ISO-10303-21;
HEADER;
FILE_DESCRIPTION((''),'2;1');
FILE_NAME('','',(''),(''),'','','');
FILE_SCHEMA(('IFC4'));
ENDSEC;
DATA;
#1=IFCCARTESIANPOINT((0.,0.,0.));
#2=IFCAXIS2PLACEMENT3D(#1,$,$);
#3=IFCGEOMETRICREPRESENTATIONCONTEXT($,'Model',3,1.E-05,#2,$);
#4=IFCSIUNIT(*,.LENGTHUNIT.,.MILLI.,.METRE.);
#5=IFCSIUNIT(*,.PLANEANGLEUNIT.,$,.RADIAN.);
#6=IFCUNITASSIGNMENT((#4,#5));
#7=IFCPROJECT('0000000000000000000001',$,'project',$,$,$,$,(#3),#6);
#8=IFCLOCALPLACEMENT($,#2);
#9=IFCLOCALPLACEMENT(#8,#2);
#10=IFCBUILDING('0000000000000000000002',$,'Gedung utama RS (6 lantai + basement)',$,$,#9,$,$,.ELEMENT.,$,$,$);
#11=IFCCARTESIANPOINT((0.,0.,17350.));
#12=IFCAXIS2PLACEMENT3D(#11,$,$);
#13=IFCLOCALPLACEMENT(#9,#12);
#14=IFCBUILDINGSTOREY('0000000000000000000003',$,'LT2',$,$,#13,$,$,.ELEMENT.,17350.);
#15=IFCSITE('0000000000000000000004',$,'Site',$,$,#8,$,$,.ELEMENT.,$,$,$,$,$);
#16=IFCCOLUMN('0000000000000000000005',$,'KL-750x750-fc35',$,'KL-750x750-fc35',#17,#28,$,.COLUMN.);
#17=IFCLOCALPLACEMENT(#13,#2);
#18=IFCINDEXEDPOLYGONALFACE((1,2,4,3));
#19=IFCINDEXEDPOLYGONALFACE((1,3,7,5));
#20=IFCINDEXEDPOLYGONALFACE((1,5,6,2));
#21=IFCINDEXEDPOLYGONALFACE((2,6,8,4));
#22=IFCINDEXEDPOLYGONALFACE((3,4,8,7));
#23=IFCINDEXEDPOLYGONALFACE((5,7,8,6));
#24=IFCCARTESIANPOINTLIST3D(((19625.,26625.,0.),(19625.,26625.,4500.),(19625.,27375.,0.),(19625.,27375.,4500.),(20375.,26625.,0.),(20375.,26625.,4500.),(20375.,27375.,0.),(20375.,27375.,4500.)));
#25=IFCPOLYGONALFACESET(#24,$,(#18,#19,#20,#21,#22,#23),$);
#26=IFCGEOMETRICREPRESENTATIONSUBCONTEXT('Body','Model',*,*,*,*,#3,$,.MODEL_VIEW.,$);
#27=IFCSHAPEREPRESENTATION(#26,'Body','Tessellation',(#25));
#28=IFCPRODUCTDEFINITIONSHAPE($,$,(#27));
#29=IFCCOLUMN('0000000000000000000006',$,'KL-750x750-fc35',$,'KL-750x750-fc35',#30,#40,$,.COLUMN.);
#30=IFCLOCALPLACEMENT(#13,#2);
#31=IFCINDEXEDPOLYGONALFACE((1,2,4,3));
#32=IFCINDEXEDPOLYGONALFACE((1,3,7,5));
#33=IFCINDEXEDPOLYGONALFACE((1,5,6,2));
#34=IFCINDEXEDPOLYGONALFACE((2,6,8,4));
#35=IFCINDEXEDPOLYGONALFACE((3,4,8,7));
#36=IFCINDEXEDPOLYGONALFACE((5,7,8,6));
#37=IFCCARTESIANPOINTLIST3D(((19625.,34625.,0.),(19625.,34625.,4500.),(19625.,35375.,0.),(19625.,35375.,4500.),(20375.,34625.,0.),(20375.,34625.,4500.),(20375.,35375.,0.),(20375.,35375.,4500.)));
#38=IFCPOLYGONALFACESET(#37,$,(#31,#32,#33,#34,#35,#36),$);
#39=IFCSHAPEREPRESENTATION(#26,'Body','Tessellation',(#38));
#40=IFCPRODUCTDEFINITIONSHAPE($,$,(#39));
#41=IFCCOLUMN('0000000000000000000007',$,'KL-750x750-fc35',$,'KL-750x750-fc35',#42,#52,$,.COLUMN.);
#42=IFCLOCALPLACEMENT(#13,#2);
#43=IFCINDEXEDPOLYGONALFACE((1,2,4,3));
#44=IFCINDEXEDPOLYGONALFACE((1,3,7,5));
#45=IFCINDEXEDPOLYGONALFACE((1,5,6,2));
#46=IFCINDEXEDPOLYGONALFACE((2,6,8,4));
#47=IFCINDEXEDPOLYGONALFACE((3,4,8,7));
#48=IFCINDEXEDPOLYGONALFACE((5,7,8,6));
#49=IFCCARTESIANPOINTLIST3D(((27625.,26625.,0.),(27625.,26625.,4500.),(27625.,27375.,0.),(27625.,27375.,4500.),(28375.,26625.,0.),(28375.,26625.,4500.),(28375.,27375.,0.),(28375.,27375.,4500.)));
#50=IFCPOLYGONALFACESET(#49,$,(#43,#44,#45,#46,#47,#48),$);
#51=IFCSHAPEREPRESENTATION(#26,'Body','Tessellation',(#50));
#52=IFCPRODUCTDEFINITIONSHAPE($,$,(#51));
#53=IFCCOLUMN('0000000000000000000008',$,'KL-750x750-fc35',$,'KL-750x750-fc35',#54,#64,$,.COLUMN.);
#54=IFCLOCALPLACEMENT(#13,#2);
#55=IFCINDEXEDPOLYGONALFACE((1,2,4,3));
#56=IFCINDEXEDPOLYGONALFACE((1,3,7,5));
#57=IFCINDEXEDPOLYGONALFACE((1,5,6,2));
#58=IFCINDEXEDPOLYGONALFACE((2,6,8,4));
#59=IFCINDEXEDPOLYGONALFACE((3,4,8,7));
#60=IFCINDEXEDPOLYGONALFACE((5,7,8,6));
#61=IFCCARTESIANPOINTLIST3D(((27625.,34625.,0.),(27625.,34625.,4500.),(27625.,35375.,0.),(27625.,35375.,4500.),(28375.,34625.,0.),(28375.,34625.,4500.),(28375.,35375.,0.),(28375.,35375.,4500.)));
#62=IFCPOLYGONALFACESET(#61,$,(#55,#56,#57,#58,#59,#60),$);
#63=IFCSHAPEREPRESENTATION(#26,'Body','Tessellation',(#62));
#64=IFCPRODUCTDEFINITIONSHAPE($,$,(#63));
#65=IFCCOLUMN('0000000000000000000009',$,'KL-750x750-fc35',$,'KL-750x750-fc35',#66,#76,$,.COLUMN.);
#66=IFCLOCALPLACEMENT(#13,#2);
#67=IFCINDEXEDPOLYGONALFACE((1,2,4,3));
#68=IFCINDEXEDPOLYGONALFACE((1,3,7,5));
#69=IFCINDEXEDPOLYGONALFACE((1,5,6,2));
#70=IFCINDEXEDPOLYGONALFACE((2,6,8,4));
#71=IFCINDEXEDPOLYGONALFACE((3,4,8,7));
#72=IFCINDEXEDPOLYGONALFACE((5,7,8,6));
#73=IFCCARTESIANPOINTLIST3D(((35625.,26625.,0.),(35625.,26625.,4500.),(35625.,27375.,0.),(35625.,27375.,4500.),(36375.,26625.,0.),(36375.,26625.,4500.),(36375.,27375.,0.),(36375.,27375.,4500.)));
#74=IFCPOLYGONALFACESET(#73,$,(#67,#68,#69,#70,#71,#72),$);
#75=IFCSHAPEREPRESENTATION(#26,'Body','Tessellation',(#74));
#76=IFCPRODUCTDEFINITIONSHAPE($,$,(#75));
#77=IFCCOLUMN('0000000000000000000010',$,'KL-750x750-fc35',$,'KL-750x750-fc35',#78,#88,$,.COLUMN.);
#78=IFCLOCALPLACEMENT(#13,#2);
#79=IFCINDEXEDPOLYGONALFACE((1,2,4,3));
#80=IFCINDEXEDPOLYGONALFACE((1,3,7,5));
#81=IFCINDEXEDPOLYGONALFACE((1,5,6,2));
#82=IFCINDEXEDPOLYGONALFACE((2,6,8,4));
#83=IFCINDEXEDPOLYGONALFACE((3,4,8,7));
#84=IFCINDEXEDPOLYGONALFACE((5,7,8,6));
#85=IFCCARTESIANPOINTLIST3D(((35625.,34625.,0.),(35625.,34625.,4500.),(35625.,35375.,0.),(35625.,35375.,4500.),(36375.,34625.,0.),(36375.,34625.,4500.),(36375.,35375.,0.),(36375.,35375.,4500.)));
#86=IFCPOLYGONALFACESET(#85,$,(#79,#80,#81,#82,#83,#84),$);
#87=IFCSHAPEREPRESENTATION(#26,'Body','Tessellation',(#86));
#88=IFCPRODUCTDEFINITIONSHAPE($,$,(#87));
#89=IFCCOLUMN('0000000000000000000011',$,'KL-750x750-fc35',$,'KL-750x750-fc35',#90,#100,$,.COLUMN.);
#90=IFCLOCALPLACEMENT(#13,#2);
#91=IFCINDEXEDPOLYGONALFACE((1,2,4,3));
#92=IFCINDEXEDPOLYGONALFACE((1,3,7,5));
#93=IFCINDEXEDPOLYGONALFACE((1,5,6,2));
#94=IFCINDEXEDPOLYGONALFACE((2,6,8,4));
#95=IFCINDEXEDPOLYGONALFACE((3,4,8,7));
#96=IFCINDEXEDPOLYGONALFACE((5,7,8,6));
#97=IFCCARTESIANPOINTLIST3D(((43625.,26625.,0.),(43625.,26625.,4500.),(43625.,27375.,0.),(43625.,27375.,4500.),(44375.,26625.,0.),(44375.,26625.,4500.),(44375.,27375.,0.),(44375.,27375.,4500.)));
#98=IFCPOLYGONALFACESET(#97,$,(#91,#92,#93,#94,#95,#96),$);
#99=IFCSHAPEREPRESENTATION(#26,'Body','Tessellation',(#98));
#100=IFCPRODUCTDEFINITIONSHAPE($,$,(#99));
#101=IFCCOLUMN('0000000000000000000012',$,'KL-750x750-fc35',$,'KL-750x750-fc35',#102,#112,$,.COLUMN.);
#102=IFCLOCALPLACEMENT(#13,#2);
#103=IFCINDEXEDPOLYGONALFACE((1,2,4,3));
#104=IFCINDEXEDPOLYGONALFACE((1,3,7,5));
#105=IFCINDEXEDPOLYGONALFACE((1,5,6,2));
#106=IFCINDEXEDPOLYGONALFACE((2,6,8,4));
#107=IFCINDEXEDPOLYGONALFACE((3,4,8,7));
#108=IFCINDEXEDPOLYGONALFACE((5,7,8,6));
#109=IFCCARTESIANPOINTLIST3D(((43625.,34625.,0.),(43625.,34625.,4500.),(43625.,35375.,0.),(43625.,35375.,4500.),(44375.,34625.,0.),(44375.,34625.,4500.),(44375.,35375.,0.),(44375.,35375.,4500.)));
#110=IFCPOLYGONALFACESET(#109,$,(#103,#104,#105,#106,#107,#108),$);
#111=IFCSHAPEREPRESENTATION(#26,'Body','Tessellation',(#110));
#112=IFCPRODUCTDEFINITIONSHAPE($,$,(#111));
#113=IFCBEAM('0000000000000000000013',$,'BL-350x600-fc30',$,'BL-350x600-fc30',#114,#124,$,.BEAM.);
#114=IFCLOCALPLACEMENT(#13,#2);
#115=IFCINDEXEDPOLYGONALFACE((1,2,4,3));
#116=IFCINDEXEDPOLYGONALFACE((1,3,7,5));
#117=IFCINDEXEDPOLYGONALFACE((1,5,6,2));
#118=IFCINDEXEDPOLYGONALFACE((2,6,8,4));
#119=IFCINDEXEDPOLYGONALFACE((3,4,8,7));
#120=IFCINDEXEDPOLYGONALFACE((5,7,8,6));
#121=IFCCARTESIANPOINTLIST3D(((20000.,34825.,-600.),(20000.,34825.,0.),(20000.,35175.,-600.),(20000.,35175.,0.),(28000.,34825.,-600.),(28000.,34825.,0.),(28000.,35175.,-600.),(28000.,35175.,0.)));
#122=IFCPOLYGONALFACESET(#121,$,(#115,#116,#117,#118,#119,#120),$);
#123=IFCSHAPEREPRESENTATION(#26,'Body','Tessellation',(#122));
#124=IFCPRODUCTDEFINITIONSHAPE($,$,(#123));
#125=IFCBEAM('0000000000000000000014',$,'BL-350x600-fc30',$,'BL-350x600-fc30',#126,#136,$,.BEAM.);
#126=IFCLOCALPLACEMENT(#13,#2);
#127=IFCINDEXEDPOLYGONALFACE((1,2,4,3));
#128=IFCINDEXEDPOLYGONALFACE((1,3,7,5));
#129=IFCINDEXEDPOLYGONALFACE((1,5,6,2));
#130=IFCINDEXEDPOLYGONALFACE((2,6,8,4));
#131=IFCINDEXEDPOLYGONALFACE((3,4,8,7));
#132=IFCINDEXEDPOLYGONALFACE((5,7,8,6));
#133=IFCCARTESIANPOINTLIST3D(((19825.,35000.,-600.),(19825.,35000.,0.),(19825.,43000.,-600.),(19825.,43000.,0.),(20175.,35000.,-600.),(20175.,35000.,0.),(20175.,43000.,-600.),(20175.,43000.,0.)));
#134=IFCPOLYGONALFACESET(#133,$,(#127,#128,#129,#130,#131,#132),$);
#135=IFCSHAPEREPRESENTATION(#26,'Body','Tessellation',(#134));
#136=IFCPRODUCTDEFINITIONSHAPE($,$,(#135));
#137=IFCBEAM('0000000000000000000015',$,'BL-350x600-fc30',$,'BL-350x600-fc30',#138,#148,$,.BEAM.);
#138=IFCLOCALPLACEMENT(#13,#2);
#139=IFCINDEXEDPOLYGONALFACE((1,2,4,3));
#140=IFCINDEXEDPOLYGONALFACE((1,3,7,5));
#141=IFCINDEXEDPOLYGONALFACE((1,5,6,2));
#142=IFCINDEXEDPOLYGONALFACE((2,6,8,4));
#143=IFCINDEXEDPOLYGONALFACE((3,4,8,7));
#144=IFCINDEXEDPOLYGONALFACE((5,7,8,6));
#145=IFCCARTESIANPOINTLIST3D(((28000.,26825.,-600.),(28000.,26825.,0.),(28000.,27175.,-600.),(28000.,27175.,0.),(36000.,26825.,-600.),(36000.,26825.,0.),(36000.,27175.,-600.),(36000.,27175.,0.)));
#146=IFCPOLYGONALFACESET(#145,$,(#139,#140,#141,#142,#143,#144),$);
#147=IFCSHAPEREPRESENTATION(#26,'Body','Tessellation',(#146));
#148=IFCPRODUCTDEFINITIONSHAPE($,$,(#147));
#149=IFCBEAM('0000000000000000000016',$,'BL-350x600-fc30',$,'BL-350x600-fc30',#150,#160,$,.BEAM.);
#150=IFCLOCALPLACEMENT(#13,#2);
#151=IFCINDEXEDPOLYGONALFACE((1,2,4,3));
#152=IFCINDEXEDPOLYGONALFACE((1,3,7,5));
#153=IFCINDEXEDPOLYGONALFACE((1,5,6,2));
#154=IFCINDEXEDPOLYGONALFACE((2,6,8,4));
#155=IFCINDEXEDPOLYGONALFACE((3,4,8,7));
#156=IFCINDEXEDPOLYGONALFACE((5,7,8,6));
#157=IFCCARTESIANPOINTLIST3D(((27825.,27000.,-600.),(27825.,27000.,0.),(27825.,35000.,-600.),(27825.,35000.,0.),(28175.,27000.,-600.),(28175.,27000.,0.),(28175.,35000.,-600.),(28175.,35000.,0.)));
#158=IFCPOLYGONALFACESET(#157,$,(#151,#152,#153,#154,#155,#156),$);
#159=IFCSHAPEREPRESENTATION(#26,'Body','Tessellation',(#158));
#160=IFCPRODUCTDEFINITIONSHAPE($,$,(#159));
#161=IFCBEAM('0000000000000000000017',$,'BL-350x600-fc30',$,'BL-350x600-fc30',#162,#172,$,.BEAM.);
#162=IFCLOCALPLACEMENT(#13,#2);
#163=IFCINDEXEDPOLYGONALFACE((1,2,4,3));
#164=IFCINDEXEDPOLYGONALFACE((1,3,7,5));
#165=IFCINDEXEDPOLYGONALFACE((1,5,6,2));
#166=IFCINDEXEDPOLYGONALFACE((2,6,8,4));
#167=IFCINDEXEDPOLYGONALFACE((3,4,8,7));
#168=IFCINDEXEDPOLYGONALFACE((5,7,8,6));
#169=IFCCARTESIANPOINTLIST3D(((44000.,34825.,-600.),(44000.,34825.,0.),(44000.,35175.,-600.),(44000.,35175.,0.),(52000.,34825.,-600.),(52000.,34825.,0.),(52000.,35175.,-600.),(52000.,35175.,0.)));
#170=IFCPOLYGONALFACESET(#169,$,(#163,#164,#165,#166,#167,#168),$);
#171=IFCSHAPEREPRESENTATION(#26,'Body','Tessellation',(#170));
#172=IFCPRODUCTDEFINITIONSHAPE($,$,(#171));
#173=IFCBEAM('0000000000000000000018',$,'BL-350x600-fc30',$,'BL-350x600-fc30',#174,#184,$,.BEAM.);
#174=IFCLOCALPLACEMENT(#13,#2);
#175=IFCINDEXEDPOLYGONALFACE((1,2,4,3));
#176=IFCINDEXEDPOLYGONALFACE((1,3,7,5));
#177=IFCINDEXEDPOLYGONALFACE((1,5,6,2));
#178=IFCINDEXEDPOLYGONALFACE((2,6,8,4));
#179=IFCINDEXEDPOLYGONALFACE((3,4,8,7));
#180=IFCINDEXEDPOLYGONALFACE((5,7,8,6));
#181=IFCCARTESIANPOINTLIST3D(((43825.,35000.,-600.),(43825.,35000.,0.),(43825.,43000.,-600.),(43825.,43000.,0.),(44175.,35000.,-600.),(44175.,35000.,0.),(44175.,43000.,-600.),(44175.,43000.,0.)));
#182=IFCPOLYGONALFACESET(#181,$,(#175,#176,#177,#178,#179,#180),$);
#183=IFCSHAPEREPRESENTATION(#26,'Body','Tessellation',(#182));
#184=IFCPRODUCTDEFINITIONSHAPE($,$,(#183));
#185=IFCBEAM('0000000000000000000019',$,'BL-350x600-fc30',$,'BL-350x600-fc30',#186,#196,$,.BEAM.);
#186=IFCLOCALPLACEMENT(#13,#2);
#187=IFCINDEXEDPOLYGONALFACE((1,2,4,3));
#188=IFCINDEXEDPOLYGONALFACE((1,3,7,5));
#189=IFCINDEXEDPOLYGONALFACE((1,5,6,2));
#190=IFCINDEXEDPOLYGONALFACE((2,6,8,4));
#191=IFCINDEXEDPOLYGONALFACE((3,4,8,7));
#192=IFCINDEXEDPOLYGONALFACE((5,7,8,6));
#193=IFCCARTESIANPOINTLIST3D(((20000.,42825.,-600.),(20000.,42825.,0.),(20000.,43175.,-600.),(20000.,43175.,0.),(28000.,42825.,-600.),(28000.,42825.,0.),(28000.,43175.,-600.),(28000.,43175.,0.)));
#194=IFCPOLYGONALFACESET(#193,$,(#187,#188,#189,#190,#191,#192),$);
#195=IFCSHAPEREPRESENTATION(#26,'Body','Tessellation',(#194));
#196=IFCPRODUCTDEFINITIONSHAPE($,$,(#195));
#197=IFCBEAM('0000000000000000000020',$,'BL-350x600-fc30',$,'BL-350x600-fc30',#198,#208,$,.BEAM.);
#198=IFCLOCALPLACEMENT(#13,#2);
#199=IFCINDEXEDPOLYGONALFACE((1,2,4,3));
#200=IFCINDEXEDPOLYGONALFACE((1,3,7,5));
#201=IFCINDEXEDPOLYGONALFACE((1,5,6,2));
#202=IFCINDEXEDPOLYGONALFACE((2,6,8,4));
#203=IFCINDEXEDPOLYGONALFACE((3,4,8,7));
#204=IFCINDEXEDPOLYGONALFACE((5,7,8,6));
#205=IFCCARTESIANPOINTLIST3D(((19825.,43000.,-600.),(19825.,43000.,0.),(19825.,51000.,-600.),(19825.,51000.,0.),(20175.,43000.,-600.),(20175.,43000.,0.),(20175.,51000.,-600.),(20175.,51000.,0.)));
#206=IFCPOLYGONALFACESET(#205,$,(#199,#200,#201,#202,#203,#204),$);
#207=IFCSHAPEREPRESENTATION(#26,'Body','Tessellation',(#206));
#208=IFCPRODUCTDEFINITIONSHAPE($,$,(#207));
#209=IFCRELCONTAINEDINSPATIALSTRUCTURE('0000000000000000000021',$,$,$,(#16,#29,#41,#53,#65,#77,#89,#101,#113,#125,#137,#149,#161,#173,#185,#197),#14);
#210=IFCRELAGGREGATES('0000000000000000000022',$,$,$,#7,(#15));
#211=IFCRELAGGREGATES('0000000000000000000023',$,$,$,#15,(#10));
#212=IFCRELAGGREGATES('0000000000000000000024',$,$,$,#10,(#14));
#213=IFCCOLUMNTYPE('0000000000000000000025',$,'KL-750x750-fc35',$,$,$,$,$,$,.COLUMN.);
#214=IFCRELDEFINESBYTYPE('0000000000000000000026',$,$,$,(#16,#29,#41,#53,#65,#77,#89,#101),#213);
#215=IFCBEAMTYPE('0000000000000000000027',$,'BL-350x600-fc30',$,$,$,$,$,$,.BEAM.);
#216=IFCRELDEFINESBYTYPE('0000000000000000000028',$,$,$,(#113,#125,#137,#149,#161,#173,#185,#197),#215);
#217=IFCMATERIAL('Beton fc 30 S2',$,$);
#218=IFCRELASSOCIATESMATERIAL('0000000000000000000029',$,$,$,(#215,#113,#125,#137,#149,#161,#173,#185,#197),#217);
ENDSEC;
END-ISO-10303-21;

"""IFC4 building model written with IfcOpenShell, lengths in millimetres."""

from ifc_helpers import new_model, si_unit, frame, origin, origin_2d, place, context, subcontext, project, spatial, rectangle, extrude, material, material_profile, profile_set, profile_usage, type_object, element, save


model = new_model("IFC4")

# Units and contexts
model_context = context("Model", 3, precision=1e-05, world=origin())
body_context = subcontext(model_context, "Body", "Model", "MODEL_VIEW")
ifc_project = project(units=[si_unit("LENGTHUNIT", "METRE", prefix="MILLI"), si_unit("PLANEANGLEUNIT", "RADIAN")], contexts=[model_context])

# Site, building, storey
site_placement = place(None, origin())
site = spatial("IfcSite", under=ifc_project, at=site_placement, Name="Site", CompositionType="ELEMENT")
building_placement = place(site_placement, origin())
building = spatial("IfcBuilding", under=site, at=building_placement, Name="Gedung utama RS (6 lantai + basement)", CompositionType="ELEMENT")
storey_placement = place(building_placement, frame((0.0, 0.0, 17350.0)))
storey = spatial("IfcBuildingStorey", under=building, at=storey_placement, Name="LT2", CompositionType="ELEMENT", Elevation=17350.0)

# Columns
ifc_material_profile_1 = material_profile(None, rectangle(XDim=750.0, YDim=750.0, at=origin_2d()), Name="KL-750x750-fc35")
ifc_profile_set_1 = profile_set([ifc_material_profile_1], Name="KL-750x750-fc35")
ifc_profile_usage_1 = profile_usage(ifc_profile_set_1, cardinal=5)
column_type = type_object("IfcColumnType", Name="KL-750x750-fc35", PredefinedType="COLUMN", material=ifc_profile_set_1)
for number, where, z_axis, x_axis, name in (
    (1, (20000.0, 27000.0, 0.0), (0.0, 0.0, 1.0), (1.0, 0.0, 0.0), "KL-750x750-fc35"),
    (2, (20000.0, 35000.0, 0.0), (0.0, 0.0, 1.0), (1.0, 0.0, 0.0), "KL-750x750-fc35"),
    (3, (28000.0, 27000.0, 0.0), (0.0, 0.0, 1.0), (1.0, 0.0, 0.0), "KL-750x750-fc35"),
    (4, (28000.0, 35000.0, 0.0), (0.0, 0.0, 1.0), (1.0, 0.0, 0.0), "KL-750x750-fc35"),
    (5, (36000.0, 27000.0, 0.0), (0.0, 0.0, 1.0), (1.0, 0.0, 0.0), "KL-750x750-fc35"),
    (6, (36000.0, 35000.0, 0.0), (0.0, 0.0, 1.0), (1.0, 0.0, 0.0), "KL-750x750-fc35"),
    (7, (44000.0, 27000.0, 0.0), (0.0, 0.0, 1.0), (1.0, 0.0, 0.0), "KL-750x750-fc35"),
    (8, (44000.0, 35000.0, 0.0), (0.0, 0.0, 1.0), (1.0, 0.0, 0.0), "KL-750x750-fc35"),
):
    element("IfcColumn", number, at=place(storey_placement, frame(where, z_axis=z_axis, x_axis=x_axis)), inside=storey, type_object=column_type, material=ifc_profile_usage_1, Name=name, ObjectType="KL-750x750-fc35", PredefinedType="COLUMN", context=body_context, shape_type="SweptSolid", body=[
        extrude(rectangle(XDim=750.0, YDim=750.0, at=origin_2d()), origin(), (0.0, 0.0, 1.0), 4500.0),
    ])

# Beams
ifc_material_1 = material(Name="Beton fc 30 S2")
ifc_material_profile_2 = material_profile(ifc_material_1, rectangle(XDim=350.0, YDim=600.0, at=origin_2d()), Name="BL-350x600-fc30")
ifc_profile_set_2 = profile_set([ifc_material_profile_2], Name="BL-350x600-fc30")
ifc_profile_usage_2 = profile_usage(ifc_profile_set_2, cardinal=8)
beam_type = type_object("IfcBeamType", Name="BL-350x600-fc30", PredefinedType="BEAM", material=ifc_profile_set_2)
beam_1_placement = place(storey_placement, frame((20000.0, 35000.0, -300.0)))
element("IfcBeam", 9, at=beam_1_placement, inside=storey, type_object=beam_type, material=ifc_profile_usage_2, Name="BL-350x600-fc30", ObjectType="BL-350x600-fc30", PredefinedType="BEAM", context=body_context, shape_type="SweptSolid", body=[
    extrude(rectangle(XDim=350.0, YDim=600.0, at=origin_2d()), frame((0.0, 0.0, 0.0), z_axis=(1.0, 0.0, 0.0), x_axis=(0.0, 1.0, 0.0)), (0.0, 0.0, 1.0), 8000.0),
])
beam_2_placement = place(storey_placement, frame((20000.0, 35000.0, -300.0)))
element("IfcBeam", 10, at=beam_2_placement, inside=storey, type_object=beam_type, material=ifc_profile_usage_2, Name="BL-350x600-fc30", ObjectType="BL-350x600-fc30", PredefinedType="BEAM", context=body_context, shape_type="SweptSolid", body=[
    extrude(rectangle(XDim=350.0, YDim=600.0, at=origin_2d()), frame((0.0, 0.0, 0.0), z_axis=(0.0, 1.0, 0.0), x_axis=(-1.0, 0.0, 0.0)), (0.0, 0.0, 1.0), 8000.0),
])
beam_3_placement = place(storey_placement, frame((28000.0, 27000.0, -300.0)))
element("IfcBeam", 11, at=beam_3_placement, inside=storey, type_object=beam_type, material=ifc_profile_usage_2, Name="BL-350x600-fc30", ObjectType="BL-350x600-fc30", PredefinedType="BEAM", context=body_context, shape_type="SweptSolid", body=[
    extrude(rectangle(XDim=350.0, YDim=600.0, at=origin_2d()), frame((0.0, 0.0, 0.0), z_axis=(1.0, 0.0, 0.0), x_axis=(0.0, 1.0, 0.0)), (0.0, 0.0, 1.0), 8000.0),
])
beam_4_placement = place(storey_placement, frame((28000.0, 27000.0, -300.0)))
element("IfcBeam", 12, at=beam_4_placement, inside=storey, type_object=beam_type, material=ifc_profile_usage_2, Name="BL-350x600-fc30", ObjectType="BL-350x600-fc30", PredefinedType="BEAM", context=body_context, shape_type="SweptSolid", body=[
    extrude(rectangle(XDim=350.0, YDim=600.0, at=origin_2d()), frame((0.0, 0.0, 0.0), z_axis=(0.0, 1.0, 0.0), x_axis=(-1.0, 0.0, 0.0)), (0.0, 0.0, 1.0), 8000.0),
])
beam_5_placement = place(storey_placement, frame((44000.0, 35000.0, -300.0)))
element("IfcBeam", 13, at=beam_5_placement, inside=storey, type_object=beam_type, material=ifc_profile_usage_2, Name="BL-350x600-fc30", ObjectType="BL-350x600-fc30", PredefinedType="BEAM", context=body_context, shape_type="SweptSolid", body=[
    extrude(rectangle(XDim=350.0, YDim=600.0, at=origin_2d()), frame((0.0, 0.0, 0.0), z_axis=(1.0, 0.0, 0.0), x_axis=(0.0, 1.0, 0.0)), (0.0, 0.0, 1.0), 8000.0),
])
beam_6_placement = place(storey_placement, frame((44000.0, 35000.0, -300.0)))
element("IfcBeam", 14, at=beam_6_placement, inside=storey, type_object=beam_type, material=ifc_profile_usage_2, Name="BL-350x600-fc30", ObjectType="BL-350x600-fc30", PredefinedType="BEAM", context=body_context, shape_type="SweptSolid", body=[
    extrude(rectangle(XDim=350.0, YDim=600.0, at=origin_2d()), frame((0.0, 0.0, 0.0), z_axis=(0.0, 1.0, 0.0), x_axis=(-1.0, 0.0, 0.0)), (0.0, 0.0, 1.0), 8000.0),
])
beam_7_placement = place(storey_placement, frame((20000.0, 43000.0, -300.0)))
element("IfcBeam", 15, at=beam_7_placement, inside=storey, type_object=beam_type, material=ifc_profile_usage_2, Name="BL-350x600-fc30", ObjectType="BL-350x600-fc30", PredefinedType="BEAM", context=body_context, shape_type="SweptSolid", body=[
    extrude(rectangle(XDim=350.0, YDim=600.0, at=origin_2d()), frame((0.0, 0.0, 0.0), z_axis=(1.0, 0.0, 0.0), x_axis=(0.0, 1.0, 0.0)), (0.0, 0.0, 1.0), 8000.0),
])
beam_8_placement = place(storey_placement, frame((20000.0, 43000.0, -300.0)))
element("IfcBeam", 16, at=beam_8_placement, inside=storey, type_object=beam_type, material=ifc_profile_usage_2, Name="BL-350x600-fc30", ObjectType="BL-350x600-fc30", PredefinedType="BEAM", context=body_context, shape_type="SweptSolid", body=[
    extrude(rectangle(XDim=350.0, YDim=600.0, at=origin_2d()), frame((0.0, 0.0, 0.0), z_axis=(0.0, 1.0, 0.0), x_axis=(-1.0, 0.0, 0.0)), (0.0, 0.0, 1.0), 8000.0),
])

save(model, "model.ifc")
